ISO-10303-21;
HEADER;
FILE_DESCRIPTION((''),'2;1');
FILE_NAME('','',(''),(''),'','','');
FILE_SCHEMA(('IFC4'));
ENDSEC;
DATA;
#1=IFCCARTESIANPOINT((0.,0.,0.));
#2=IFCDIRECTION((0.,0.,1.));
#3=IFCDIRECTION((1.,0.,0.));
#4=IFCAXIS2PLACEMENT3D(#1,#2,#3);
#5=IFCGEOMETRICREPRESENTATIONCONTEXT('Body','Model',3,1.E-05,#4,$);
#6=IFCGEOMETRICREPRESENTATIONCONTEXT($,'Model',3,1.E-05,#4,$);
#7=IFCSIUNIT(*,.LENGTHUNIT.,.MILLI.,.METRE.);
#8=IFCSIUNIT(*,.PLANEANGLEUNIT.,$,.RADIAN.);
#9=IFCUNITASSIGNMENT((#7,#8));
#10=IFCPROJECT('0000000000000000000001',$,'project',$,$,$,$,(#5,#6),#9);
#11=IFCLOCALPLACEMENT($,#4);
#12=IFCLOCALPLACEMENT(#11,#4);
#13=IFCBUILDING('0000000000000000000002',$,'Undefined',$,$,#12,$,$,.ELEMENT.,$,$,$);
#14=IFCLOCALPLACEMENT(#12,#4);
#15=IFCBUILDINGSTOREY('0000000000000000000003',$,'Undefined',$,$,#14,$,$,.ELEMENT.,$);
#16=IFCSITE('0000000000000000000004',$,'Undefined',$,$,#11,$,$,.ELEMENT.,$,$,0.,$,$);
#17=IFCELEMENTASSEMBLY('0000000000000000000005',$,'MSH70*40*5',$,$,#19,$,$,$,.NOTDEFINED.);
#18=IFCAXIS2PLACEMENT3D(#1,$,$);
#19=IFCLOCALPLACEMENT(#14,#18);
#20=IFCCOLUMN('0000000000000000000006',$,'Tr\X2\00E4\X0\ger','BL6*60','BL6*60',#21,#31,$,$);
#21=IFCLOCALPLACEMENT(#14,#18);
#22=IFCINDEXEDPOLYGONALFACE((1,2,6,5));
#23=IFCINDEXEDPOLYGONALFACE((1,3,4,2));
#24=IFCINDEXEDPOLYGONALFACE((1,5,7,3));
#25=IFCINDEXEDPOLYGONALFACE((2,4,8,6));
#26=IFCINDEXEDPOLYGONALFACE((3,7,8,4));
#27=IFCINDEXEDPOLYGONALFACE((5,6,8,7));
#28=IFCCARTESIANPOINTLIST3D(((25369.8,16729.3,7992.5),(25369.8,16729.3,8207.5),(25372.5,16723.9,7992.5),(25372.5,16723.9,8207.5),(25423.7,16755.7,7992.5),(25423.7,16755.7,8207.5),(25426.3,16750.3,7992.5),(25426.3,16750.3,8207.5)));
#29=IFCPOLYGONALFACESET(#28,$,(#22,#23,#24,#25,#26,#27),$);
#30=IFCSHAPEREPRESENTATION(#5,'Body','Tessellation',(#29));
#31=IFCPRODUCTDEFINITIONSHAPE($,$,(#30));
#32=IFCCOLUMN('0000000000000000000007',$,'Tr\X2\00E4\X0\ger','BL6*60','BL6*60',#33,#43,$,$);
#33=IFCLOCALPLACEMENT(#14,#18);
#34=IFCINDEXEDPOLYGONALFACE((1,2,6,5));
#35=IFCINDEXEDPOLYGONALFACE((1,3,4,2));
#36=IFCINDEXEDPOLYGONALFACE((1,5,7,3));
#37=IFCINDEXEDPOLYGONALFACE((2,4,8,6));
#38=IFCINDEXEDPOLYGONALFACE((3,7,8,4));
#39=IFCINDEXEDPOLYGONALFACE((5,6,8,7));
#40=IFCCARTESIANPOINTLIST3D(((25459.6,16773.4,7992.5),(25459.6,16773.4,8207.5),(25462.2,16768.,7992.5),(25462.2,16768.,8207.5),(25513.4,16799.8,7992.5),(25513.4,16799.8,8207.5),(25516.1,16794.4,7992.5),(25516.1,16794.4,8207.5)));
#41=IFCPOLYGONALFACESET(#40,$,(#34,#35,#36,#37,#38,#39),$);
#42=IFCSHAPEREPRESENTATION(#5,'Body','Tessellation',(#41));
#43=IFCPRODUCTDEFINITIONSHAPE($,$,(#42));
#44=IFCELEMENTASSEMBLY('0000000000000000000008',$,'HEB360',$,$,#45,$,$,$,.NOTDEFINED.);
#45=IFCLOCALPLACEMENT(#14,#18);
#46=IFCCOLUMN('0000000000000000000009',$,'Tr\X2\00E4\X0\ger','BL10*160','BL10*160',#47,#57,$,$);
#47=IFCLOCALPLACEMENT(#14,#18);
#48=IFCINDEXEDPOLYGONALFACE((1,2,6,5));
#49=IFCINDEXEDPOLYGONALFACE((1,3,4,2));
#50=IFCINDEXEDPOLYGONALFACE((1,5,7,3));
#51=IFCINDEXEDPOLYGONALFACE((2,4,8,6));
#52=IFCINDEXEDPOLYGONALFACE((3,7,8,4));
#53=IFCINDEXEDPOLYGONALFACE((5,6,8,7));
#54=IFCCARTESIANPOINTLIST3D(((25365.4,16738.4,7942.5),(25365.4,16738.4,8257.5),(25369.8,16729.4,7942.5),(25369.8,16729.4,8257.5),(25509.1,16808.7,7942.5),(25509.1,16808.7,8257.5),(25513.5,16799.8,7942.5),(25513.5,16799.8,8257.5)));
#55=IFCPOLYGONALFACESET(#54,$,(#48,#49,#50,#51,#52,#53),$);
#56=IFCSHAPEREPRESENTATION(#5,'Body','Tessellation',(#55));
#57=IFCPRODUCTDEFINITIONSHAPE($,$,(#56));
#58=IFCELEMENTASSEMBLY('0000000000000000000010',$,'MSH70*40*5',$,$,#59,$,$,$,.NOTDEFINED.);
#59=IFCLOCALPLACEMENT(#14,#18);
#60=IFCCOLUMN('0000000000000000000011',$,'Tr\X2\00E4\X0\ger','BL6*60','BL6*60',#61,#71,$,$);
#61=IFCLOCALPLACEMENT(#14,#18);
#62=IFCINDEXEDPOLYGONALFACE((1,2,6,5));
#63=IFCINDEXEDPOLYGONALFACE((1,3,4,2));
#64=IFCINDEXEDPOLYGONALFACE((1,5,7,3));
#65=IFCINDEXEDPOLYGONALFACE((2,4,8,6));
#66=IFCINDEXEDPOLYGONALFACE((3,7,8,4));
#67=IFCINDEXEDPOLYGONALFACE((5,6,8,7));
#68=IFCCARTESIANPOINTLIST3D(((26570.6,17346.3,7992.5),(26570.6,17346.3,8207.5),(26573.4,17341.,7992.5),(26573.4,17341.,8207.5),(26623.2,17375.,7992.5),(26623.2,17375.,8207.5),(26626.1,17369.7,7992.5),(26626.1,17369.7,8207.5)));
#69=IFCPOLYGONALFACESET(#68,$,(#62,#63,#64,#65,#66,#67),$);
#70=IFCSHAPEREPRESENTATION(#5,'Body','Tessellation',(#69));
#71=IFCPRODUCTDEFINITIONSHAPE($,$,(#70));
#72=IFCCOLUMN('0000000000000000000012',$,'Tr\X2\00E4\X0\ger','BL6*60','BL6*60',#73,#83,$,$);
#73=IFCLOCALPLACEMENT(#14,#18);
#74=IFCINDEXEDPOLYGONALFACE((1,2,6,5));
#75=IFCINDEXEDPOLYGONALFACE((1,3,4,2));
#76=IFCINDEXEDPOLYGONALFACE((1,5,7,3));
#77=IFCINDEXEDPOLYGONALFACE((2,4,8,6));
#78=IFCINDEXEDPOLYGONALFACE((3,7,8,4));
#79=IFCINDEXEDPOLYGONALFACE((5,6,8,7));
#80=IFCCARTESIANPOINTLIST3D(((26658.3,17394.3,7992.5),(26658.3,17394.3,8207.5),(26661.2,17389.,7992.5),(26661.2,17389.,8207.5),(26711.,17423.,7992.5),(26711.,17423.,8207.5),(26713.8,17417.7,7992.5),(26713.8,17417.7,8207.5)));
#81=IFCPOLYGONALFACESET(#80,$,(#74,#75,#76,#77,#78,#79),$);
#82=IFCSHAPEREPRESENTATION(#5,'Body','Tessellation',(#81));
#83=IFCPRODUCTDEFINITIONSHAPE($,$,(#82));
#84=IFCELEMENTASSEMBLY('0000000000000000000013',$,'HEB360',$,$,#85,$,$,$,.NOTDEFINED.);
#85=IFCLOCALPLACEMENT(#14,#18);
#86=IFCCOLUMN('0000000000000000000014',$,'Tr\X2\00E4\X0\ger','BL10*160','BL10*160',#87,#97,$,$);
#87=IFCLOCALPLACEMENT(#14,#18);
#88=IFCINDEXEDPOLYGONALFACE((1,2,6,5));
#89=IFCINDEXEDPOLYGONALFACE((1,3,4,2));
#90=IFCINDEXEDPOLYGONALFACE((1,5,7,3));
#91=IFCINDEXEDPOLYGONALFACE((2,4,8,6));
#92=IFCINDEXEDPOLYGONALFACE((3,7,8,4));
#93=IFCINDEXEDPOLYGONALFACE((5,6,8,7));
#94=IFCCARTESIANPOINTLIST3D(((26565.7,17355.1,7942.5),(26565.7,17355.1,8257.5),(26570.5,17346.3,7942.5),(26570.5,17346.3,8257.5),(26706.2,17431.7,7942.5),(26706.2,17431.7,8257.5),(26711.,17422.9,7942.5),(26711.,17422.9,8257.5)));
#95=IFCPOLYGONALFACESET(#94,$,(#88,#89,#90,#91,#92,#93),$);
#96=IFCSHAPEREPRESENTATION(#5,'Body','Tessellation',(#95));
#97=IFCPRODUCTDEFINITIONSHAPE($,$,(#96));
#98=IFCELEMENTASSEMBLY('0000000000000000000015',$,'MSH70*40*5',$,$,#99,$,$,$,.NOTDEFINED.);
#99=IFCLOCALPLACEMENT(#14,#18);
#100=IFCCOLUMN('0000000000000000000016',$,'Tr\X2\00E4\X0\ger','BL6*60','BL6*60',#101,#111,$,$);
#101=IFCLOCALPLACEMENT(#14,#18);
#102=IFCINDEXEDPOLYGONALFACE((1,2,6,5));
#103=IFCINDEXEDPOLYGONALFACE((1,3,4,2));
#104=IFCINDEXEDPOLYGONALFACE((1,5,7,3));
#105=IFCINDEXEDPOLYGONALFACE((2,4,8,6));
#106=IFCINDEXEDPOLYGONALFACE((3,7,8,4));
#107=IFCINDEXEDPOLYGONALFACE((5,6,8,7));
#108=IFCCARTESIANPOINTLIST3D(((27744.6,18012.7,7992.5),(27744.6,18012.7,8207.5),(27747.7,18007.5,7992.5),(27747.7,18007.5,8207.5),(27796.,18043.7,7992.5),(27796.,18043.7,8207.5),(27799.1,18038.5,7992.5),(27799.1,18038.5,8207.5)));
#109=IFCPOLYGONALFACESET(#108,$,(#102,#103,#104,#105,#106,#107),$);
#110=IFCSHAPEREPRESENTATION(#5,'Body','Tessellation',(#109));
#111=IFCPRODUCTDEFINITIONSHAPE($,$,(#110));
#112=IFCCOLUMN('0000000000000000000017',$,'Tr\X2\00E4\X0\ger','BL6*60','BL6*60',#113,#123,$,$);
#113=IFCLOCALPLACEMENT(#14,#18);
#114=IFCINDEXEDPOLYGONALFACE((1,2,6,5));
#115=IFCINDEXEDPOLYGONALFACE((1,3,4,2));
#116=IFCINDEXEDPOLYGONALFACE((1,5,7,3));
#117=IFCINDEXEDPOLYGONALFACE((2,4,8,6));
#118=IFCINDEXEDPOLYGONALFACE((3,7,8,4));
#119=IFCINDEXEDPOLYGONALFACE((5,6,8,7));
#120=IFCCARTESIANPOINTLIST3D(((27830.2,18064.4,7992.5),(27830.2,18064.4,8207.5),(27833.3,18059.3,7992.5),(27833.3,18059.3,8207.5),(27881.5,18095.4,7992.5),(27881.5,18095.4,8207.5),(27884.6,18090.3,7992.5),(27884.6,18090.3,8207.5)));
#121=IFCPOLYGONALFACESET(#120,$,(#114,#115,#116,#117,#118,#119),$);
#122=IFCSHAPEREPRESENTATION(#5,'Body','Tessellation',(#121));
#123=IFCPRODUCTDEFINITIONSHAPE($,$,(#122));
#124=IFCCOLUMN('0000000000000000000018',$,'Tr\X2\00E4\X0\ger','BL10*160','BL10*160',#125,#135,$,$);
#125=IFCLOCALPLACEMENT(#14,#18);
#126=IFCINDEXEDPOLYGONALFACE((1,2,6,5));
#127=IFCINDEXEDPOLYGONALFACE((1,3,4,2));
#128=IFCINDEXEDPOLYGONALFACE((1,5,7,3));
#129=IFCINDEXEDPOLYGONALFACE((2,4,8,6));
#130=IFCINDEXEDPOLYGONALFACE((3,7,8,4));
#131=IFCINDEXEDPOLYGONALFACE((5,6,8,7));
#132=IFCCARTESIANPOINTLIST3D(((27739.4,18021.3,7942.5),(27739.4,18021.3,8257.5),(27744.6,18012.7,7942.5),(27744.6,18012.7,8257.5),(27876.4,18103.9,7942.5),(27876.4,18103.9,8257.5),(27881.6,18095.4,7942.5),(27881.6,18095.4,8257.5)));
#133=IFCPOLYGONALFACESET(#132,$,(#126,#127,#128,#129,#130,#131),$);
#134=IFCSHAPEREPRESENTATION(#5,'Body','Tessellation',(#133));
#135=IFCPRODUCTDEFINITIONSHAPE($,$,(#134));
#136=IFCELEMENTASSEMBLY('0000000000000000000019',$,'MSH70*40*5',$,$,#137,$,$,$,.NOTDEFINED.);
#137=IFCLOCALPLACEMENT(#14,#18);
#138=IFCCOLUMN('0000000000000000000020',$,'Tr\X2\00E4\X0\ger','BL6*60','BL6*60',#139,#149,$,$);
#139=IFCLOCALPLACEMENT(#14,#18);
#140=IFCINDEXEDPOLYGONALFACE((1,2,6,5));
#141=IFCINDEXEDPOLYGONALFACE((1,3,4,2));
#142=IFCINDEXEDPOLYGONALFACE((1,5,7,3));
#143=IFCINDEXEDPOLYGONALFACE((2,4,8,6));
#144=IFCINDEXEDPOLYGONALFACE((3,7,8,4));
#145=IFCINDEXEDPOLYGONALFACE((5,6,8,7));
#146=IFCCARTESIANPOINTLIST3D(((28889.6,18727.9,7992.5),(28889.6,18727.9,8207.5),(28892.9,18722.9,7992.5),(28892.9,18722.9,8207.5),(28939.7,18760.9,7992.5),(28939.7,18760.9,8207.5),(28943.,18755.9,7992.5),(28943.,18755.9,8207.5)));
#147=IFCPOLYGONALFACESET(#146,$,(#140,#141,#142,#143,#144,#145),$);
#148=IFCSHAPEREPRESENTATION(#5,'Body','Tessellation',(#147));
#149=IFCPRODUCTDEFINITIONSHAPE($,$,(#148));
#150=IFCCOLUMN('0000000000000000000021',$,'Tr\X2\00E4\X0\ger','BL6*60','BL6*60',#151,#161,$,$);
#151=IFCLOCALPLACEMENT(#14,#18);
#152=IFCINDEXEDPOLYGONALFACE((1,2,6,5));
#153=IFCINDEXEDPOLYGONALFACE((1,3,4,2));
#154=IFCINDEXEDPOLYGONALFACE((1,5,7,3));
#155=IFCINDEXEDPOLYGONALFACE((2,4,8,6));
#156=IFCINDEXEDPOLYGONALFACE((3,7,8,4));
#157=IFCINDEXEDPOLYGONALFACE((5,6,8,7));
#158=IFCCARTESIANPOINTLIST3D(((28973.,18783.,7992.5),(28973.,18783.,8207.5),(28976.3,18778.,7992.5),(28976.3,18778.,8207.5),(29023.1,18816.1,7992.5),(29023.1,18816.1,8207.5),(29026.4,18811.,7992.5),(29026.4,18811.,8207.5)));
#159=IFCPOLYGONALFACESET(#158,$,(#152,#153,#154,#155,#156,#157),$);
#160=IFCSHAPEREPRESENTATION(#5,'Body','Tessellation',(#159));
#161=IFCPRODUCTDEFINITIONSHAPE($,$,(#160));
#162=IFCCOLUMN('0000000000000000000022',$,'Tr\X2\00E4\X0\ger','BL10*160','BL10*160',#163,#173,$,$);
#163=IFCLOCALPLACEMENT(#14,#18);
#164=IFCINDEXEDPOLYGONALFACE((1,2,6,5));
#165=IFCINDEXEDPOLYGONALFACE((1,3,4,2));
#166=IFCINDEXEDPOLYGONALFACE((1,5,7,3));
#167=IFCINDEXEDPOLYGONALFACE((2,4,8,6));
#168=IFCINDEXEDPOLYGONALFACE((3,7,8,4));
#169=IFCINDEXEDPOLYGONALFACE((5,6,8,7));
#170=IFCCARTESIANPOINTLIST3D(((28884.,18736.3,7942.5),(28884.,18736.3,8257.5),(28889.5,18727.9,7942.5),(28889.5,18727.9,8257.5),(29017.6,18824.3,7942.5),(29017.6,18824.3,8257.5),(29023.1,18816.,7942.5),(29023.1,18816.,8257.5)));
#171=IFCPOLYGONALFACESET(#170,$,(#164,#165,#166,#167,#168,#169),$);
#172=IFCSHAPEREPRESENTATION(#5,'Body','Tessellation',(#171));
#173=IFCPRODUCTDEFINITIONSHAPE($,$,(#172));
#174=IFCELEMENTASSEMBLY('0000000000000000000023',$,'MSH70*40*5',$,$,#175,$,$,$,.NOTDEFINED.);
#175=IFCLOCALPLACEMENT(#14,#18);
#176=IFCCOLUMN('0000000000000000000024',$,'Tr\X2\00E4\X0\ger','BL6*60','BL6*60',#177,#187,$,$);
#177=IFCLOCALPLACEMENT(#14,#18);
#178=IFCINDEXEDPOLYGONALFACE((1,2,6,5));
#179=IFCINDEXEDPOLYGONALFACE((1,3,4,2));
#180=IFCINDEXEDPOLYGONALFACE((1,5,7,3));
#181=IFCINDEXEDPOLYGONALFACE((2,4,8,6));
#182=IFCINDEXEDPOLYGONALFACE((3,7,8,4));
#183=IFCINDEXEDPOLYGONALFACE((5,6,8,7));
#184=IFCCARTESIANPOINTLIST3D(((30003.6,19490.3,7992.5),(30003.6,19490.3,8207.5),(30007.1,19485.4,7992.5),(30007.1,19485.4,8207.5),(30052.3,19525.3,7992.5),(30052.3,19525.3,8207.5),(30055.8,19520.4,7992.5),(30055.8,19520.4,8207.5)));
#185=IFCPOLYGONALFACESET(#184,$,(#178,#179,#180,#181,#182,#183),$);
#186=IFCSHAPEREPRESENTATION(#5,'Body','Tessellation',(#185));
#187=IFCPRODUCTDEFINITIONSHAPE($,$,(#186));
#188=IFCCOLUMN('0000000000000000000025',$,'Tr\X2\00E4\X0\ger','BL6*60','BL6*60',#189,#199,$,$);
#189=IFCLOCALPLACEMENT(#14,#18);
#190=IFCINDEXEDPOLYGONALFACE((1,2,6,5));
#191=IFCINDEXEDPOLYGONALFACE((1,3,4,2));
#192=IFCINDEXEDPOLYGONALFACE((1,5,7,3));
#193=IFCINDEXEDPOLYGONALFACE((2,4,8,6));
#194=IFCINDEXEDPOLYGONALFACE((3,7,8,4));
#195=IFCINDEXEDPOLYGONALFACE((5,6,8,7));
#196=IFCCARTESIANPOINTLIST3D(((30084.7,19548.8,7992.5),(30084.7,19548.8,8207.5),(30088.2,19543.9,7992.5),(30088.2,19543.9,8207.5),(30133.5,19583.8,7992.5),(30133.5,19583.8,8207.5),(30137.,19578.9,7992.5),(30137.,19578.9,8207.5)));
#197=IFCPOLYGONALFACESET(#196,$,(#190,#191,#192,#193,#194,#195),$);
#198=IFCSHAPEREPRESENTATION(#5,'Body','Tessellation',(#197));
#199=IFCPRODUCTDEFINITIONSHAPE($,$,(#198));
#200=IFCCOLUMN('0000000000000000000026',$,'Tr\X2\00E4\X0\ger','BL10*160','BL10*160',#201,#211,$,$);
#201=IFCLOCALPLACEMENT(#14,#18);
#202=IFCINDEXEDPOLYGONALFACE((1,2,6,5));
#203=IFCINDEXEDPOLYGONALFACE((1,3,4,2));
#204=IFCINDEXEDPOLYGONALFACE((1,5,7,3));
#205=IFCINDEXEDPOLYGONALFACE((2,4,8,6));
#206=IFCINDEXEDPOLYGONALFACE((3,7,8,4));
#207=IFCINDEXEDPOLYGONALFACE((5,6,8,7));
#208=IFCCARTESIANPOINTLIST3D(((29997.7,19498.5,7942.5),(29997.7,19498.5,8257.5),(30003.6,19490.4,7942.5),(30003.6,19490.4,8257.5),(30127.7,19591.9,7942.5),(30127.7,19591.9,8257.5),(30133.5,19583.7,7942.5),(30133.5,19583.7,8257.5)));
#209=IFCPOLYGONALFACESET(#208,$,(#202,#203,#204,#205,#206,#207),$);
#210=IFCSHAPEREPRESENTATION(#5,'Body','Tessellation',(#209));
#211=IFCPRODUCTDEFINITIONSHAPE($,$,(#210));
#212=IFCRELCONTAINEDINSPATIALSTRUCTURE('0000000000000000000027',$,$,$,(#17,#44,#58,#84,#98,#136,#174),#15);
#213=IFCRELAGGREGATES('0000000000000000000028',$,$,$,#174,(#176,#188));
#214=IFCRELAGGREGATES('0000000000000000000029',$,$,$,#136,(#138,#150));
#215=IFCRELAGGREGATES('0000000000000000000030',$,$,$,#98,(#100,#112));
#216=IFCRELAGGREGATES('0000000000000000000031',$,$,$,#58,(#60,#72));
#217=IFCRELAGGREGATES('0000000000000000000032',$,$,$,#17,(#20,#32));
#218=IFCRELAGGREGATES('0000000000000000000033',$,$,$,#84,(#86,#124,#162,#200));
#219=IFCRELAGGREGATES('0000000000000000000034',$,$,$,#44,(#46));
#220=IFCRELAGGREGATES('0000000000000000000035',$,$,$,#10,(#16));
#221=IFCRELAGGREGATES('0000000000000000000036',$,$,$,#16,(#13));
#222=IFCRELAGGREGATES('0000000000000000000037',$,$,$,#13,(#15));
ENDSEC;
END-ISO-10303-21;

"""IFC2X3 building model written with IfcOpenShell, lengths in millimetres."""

from ifc_helpers import new_model, si_unit, frame, origin_with_axes, origin_2d_with_axis, place, context, project, spatial, rectangle, extrude, element, aggregate, save


model = new_model("IFC2X3")

# Units and contexts
model_context_1 = context("Model", 3, precision=1e-05, world=origin_with_axes(), identifier="Body")
model_context_2 = context("Model", 3, precision=1e-05, world=origin_with_axes())
ifc_project = project(units=[si_unit("LENGTHUNIT", "METRE", prefix="MILLI"), si_unit("PLANEANGLEUNIT", "RADIAN")], contexts=[model_context_1, model_context_2])

# Site, building, storey
site_placement = place(None, origin_with_axes())
site = spatial("IfcSite", under=ifc_project, at=site_placement, Name="Undefined", CompositionType="ELEMENT", RefElevation=0.0)
building_placement = place(site_placement, origin_with_axes())
building = spatial("IfcBuilding", under=site, at=building_placement, Name="Undefined", CompositionType="ELEMENT")
storey_placement = place(building_placement, origin_with_axes())
storey = spatial("IfcBuildingStorey", under=building, at=storey_placement, Name="Undefined", CompositionType="ELEMENT")

# Element assembly, columns
assembly_1 = element("IfcElementAssembly", 1, inside=storey, Name="MSH70*40*5", PredefinedType="NOTDEFINED")
column_1_placement = place(storey_placement, frame((25398.1, 16739.8, 7992.5), z_axis=(0.0, 0.0, 1.0), x_axis=(1.0, 0.0, 0.0)))
column_1 = element("IfcColumn", 2, at=column_1_placement, Name="Träger", Description="BL6*60", ObjectType="BL6*60", context=model_context_1, shape_type="SweptSolid", body=[
    extrude(rectangle(XDim=6.0, YDim=60.0, at=origin_2d_with_axis()), frame((0.0, 0.0, 215.0), z_axis=(0.0, 0.0, -1.0), x_axis=(0.439939, -0.898028, 0.0)), (0.0, 0.0, 1.0), 215.0),
])
column_2_placement = place(storey_placement, frame((25487.8, 16783.9, 7992.5), z_axis=(0.0, 0.0, 1.0), x_axis=(1.0, 0.0, 0.0)))
column_2 = element("IfcColumn", 3, at=column_2_placement, Name="Träger", Description="BL6*60", ObjectType="BL6*60", context=model_context_1, shape_type="SweptSolid", body=[
    extrude(rectangle(XDim=6.0, YDim=60.0, at=origin_2d_with_axis()), frame((0.0, 0.0, 215.0), z_axis=(0.0, 0.0, -1.0), x_axis=(0.439939, -0.898028, 0.0)), (0.0, 0.0, 1.0), 215.0),
])

# Element assembly, column
assembly_2 = element("IfcElementAssembly", 4, inside=storey, Name="HEB360", PredefinedType="NOTDEFINED")
column_3_placement = place(storey_placement, frame((25439.4, 16769.1, 7942.5), z_axis=(0.0, 0.0, 1.0), x_axis=(1.0, 0.0, 0.0)))
column_3 = element("IfcColumn", 5, at=column_3_placement, Name="Träger", Description="BL10*160", ObjectType="BL10*160", context=model_context_1, shape_type="SweptSolid", body=[
    extrude(rectangle(XDim=10.0, YDim=160.0, at=origin_2d_with_axis()), frame((0.0, 0.0, 315.0), z_axis=(0.0, 0.0, -1.0), x_axis=(0.439939, -0.898028, 0.0)), (0.0, 0.0, 1.0), 315.0),
])

# Element assembly, columns
assembly_3 = element("IfcElementAssembly", 6, inside=storey, Name="MSH70*40*5", PredefinedType="NOTDEFINED")
column_4_placement = place(storey_placement, frame((26598.3, 17358.0, 7992.5), z_axis=(0.0, 0.0, 1.0), x_axis=(1.0, 0.0, 0.0)))
column_4 = element("IfcColumn", 7, at=column_4_placement, Name="Träger", Description="BL6*60", ObjectType="BL6*60", context=model_context_1, shape_type="SweptSolid", body=[
    extrude(rectangle(XDim=6.0, YDim=60.0, at=origin_2d_with_axis()), frame((0.0, 0.0, 215.0), z_axis=(0.0, 0.0, -1.0), x_axis=(0.478692, -0.877983, 0.0)), (0.0, 0.0, 1.0), 215.0),
])
column_5_placement = place(storey_placement, frame((26686.1, 17406.0, 7992.5), z_axis=(0.0, 0.0, 1.0), x_axis=(1.0, 0.0, 0.0)))
column_5 = element("IfcColumn", 8, at=column_5_placement, Name="Träger", Description="BL6*60", ObjectType="BL6*60", context=model_context_1, shape_type="SweptSolid", body=[
    extrude(rectangle(XDim=6.0, YDim=60.0, at=origin_2d_with_axis()), frame((0.0, 0.0, 215.0), z_axis=(0.0, 0.0, -1.0), x_axis=(0.478692, -0.877983, 0.0)), (0.0, 0.0, 1.0), 215.0),
])

# Element assembly, column
assembly_4 = element("IfcElementAssembly", 9, inside=storey, Name="HEB360", PredefinedType="NOTDEFINED")
column_6_placement = place(storey_placement, frame((26638.4, 17389.0, 7942.5), z_axis=(0.0, 0.0, 1.0), x_axis=(1.0, 0.0, 0.0)))
column_6 = element("IfcColumn", 10, at=column_6_placement, Name="Träger", Description="BL10*160", ObjectType="BL10*160", context=model_context_1, shape_type="SweptSolid", body=[
    extrude(rectangle(XDim=10.0, YDim=160.0, at=origin_2d_with_axis()), frame((0.0, 0.0, 315.0), z_axis=(0.0, 0.0, -1.0), x_axis=(0.478692, -0.877983, 0.0)), (0.0, 0.0, 1.0), 315.0),
])

# Element assembly, columns
assembly_5 = element("IfcElementAssembly", 11, inside=storey, Name="MSH70*40*5", PredefinedType="NOTDEFINED")
column_7_placement = place(storey_placement, frame((27771.8, 18025.6, 7992.5), z_axis=(0.0, 0.0, 1.0), x_axis=(1.0, 0.0, 0.0)))
column_7 = element("IfcColumn", 12, at=column_7_placement, Name="Träger", Description="BL6*60", ObjectType="BL6*60", context=model_context_1, shape_type="SweptSolid", body=[
    extrude(rectangle(XDim=6.0, YDim=60.0, at=origin_2d_with_axis()), frame((0.0, 0.0, 215.0), z_axis=(0.0, 0.0, -1.0), x_axis=(0.516533, -0.856267, 0.0)), (0.0, 0.0, 1.0), 215.0),
])
column_8_placement = place(storey_placement, frame((27857.4, 18077.4, 7992.5), z_axis=(0.0, 0.0, 1.0), x_axis=(1.0, 0.0, 0.0)))
column_8 = element("IfcColumn", 13, at=column_8_placement, Name="Träger", Description="BL6*60", ObjectType="BL6*60", context=model_context_1, shape_type="SweptSolid", body=[
    extrude(rectangle(XDim=6.0, YDim=60.0, at=origin_2d_with_axis()), frame((0.0, 0.0, 215.0), z_axis=(0.0, 0.0, -1.0), x_axis=(0.516533, -0.856267, 0.0)), (0.0, 0.0, 1.0), 215.0),
])

# Column
column_9_placement = place(storey_placement, frame((27810.5, 18058.3, 7942.5), z_axis=(0.0, 0.0, 1.0), x_axis=(1.0, 0.0, 0.0)))
column_9 = element("IfcColumn", 14, at=column_9_placement, Name="Träger", Description="BL10*160", ObjectType="BL10*160", context=model_context_1, shape_type="SweptSolid", body=[
    extrude(rectangle(XDim=10.0, YDim=160.0, at=origin_2d_with_axis()), frame((0.0, 0.0, 315.0), z_axis=(0.0, 0.0, -1.0), x_axis=(0.516533, -0.856267, 0.0)), (0.0, 0.0, 1.0), 315.0),
])

# Element assembly, columns
assembly_6 = element("IfcElementAssembly", 15, inside=storey, Name="MSH70*40*5", PredefinedType="NOTDEFINED")
column_10_placement = place(storey_placement, frame((28916.3, 18741.9, 7992.5), z_axis=(0.0, 0.0, 1.0), x_axis=(1.0, 0.0, 0.0)))
column_10 = element("IfcColumn", 16, at=column_10_placement, Name="Träger", Description="BL6*60", ObjectType="BL6*60", context=model_context_1, shape_type="SweptSolid", body=[
    extrude(rectangle(XDim=6.0, YDim=60.0, at=origin_2d_with_axis()), frame((0.0, 0.0, 215.0), z_axis=(0.0, 0.0, -1.0), x_axis=(0.550481, -0.834848, 0.0)), (0.0, 0.0, 1.0), 215.0),
])
column_11_placement = place(storey_placement, frame((28999.7, 18797.0, 7992.5), z_axis=(0.0, 0.0, 1.0), x_axis=(1.0, 0.0, 0.0)))
column_11 = element("IfcColumn", 17, at=column_11_placement, Name="Träger", Description="BL6*60", ObjectType="BL6*60", context=model_context_1, shape_type="SweptSolid", body=[
    extrude(rectangle(XDim=6.0, YDim=60.0, at=origin_2d_with_axis()), frame((0.0, 0.0, 215.0), z_axis=(0.0, 0.0, -1.0), x_axis=(0.550481, -0.834848, 0.0)), (0.0, 0.0, 1.0), 215.0),
])

# Column
column_12_placement = place(storey_placement, frame((28953.6, 18776.1, 7942.5), z_axis=(0.0, 0.0, 1.0), x_axis=(1.0, 0.0, 0.0)))
column_12 = element("IfcColumn", 18, at=column_12_placement, Name="Träger", Description="BL10*160", ObjectType="BL10*160", context=model_context_1, shape_type="SweptSolid", body=[
    extrude(rectangle(XDim=10.0, YDim=160.0, at=origin_2d_with_axis()), frame((0.0, 0.0, 315.0), z_axis=(0.0, 0.0, -1.0), x_axis=(0.550481, -0.834848, 0.0)), (0.0, 0.0, 1.0), 315.0),
])

# Element assembly, columns
assembly_7 = element("IfcElementAssembly", 19, inside=storey, Name="MSH70*40*5", PredefinedType="NOTDEFINED")
column_13_placement = place(storey_placement, frame((30029.7, 19505.4, 7992.5), z_axis=(0.0, 0.0, 1.0), x_axis=(1.0, 0.0, 0.0)))
column_13 = element("IfcColumn", 20, at=column_13_placement, Name="Träger", Description="BL6*60", ObjectType="BL6*60", context=model_context_1, shape_type="SweptSolid", body=[
    extrude(rectangle(XDim=6.0, YDim=60.0, at=origin_2d_with_axis()), frame((0.0, 0.0, 215.0), z_axis=(0.0, 0.0, -1.0), x_axis=(0.583541, -0.812084, 0.0)), (0.0, 0.0, 1.0), 215.0),
])
column_14_placement = place(storey_placement, frame((30110.8, 19563.8, 7992.5), z_axis=(0.0, 0.0, 1.0), x_axis=(1.0, 0.0, 0.0)))
column_14 = element("IfcColumn", 21, at=column_14_placement, Name="Träger", Description="BL6*60", ObjectType="BL6*60", context=model_context_1, shape_type="SweptSolid", body=[
    extrude(rectangle(XDim=6.0, YDim=60.0, at=origin_2d_with_axis()), frame((0.0, 0.0, 215.0), z_axis=(0.0, 0.0, -1.0), x_axis=(0.583541, -0.812084, 0.0)), (0.0, 0.0, 1.0), 215.0),
])

# Column
column_15_placement = place(storey_placement, frame((30065.6, 19541.1, 7942.5), z_axis=(0.0, 0.0, 1.0), x_axis=(1.0, 0.0, 0.0)))
column_15 = element("IfcColumn", 22, at=column_15_placement, Name="Träger", Description="BL10*160", ObjectType="BL10*160", context=model_context_1, shape_type="SweptSolid", body=[
    extrude(rectangle(XDim=10.0, YDim=160.0, at=origin_2d_with_axis()), frame((0.0, 0.0, 315.0), z_axis=(0.0, 0.0, -1.0), x_axis=(0.583541, -0.812084, 0.0)), (0.0, 0.0, 1.0), 315.0),
])
aggregate(assembly_7, [column_13, column_14])
aggregate(assembly_6, [column_10, column_11])
aggregate(assembly_5, [column_7, column_8])
aggregate(assembly_3, [column_4, column_5])
aggregate(assembly_1, [column_1, column_2])
aggregate(assembly_4, [column_6, column_9, column_12, column_15])
aggregate(assembly_2, [column_3])

save(model, "model.ifc")
